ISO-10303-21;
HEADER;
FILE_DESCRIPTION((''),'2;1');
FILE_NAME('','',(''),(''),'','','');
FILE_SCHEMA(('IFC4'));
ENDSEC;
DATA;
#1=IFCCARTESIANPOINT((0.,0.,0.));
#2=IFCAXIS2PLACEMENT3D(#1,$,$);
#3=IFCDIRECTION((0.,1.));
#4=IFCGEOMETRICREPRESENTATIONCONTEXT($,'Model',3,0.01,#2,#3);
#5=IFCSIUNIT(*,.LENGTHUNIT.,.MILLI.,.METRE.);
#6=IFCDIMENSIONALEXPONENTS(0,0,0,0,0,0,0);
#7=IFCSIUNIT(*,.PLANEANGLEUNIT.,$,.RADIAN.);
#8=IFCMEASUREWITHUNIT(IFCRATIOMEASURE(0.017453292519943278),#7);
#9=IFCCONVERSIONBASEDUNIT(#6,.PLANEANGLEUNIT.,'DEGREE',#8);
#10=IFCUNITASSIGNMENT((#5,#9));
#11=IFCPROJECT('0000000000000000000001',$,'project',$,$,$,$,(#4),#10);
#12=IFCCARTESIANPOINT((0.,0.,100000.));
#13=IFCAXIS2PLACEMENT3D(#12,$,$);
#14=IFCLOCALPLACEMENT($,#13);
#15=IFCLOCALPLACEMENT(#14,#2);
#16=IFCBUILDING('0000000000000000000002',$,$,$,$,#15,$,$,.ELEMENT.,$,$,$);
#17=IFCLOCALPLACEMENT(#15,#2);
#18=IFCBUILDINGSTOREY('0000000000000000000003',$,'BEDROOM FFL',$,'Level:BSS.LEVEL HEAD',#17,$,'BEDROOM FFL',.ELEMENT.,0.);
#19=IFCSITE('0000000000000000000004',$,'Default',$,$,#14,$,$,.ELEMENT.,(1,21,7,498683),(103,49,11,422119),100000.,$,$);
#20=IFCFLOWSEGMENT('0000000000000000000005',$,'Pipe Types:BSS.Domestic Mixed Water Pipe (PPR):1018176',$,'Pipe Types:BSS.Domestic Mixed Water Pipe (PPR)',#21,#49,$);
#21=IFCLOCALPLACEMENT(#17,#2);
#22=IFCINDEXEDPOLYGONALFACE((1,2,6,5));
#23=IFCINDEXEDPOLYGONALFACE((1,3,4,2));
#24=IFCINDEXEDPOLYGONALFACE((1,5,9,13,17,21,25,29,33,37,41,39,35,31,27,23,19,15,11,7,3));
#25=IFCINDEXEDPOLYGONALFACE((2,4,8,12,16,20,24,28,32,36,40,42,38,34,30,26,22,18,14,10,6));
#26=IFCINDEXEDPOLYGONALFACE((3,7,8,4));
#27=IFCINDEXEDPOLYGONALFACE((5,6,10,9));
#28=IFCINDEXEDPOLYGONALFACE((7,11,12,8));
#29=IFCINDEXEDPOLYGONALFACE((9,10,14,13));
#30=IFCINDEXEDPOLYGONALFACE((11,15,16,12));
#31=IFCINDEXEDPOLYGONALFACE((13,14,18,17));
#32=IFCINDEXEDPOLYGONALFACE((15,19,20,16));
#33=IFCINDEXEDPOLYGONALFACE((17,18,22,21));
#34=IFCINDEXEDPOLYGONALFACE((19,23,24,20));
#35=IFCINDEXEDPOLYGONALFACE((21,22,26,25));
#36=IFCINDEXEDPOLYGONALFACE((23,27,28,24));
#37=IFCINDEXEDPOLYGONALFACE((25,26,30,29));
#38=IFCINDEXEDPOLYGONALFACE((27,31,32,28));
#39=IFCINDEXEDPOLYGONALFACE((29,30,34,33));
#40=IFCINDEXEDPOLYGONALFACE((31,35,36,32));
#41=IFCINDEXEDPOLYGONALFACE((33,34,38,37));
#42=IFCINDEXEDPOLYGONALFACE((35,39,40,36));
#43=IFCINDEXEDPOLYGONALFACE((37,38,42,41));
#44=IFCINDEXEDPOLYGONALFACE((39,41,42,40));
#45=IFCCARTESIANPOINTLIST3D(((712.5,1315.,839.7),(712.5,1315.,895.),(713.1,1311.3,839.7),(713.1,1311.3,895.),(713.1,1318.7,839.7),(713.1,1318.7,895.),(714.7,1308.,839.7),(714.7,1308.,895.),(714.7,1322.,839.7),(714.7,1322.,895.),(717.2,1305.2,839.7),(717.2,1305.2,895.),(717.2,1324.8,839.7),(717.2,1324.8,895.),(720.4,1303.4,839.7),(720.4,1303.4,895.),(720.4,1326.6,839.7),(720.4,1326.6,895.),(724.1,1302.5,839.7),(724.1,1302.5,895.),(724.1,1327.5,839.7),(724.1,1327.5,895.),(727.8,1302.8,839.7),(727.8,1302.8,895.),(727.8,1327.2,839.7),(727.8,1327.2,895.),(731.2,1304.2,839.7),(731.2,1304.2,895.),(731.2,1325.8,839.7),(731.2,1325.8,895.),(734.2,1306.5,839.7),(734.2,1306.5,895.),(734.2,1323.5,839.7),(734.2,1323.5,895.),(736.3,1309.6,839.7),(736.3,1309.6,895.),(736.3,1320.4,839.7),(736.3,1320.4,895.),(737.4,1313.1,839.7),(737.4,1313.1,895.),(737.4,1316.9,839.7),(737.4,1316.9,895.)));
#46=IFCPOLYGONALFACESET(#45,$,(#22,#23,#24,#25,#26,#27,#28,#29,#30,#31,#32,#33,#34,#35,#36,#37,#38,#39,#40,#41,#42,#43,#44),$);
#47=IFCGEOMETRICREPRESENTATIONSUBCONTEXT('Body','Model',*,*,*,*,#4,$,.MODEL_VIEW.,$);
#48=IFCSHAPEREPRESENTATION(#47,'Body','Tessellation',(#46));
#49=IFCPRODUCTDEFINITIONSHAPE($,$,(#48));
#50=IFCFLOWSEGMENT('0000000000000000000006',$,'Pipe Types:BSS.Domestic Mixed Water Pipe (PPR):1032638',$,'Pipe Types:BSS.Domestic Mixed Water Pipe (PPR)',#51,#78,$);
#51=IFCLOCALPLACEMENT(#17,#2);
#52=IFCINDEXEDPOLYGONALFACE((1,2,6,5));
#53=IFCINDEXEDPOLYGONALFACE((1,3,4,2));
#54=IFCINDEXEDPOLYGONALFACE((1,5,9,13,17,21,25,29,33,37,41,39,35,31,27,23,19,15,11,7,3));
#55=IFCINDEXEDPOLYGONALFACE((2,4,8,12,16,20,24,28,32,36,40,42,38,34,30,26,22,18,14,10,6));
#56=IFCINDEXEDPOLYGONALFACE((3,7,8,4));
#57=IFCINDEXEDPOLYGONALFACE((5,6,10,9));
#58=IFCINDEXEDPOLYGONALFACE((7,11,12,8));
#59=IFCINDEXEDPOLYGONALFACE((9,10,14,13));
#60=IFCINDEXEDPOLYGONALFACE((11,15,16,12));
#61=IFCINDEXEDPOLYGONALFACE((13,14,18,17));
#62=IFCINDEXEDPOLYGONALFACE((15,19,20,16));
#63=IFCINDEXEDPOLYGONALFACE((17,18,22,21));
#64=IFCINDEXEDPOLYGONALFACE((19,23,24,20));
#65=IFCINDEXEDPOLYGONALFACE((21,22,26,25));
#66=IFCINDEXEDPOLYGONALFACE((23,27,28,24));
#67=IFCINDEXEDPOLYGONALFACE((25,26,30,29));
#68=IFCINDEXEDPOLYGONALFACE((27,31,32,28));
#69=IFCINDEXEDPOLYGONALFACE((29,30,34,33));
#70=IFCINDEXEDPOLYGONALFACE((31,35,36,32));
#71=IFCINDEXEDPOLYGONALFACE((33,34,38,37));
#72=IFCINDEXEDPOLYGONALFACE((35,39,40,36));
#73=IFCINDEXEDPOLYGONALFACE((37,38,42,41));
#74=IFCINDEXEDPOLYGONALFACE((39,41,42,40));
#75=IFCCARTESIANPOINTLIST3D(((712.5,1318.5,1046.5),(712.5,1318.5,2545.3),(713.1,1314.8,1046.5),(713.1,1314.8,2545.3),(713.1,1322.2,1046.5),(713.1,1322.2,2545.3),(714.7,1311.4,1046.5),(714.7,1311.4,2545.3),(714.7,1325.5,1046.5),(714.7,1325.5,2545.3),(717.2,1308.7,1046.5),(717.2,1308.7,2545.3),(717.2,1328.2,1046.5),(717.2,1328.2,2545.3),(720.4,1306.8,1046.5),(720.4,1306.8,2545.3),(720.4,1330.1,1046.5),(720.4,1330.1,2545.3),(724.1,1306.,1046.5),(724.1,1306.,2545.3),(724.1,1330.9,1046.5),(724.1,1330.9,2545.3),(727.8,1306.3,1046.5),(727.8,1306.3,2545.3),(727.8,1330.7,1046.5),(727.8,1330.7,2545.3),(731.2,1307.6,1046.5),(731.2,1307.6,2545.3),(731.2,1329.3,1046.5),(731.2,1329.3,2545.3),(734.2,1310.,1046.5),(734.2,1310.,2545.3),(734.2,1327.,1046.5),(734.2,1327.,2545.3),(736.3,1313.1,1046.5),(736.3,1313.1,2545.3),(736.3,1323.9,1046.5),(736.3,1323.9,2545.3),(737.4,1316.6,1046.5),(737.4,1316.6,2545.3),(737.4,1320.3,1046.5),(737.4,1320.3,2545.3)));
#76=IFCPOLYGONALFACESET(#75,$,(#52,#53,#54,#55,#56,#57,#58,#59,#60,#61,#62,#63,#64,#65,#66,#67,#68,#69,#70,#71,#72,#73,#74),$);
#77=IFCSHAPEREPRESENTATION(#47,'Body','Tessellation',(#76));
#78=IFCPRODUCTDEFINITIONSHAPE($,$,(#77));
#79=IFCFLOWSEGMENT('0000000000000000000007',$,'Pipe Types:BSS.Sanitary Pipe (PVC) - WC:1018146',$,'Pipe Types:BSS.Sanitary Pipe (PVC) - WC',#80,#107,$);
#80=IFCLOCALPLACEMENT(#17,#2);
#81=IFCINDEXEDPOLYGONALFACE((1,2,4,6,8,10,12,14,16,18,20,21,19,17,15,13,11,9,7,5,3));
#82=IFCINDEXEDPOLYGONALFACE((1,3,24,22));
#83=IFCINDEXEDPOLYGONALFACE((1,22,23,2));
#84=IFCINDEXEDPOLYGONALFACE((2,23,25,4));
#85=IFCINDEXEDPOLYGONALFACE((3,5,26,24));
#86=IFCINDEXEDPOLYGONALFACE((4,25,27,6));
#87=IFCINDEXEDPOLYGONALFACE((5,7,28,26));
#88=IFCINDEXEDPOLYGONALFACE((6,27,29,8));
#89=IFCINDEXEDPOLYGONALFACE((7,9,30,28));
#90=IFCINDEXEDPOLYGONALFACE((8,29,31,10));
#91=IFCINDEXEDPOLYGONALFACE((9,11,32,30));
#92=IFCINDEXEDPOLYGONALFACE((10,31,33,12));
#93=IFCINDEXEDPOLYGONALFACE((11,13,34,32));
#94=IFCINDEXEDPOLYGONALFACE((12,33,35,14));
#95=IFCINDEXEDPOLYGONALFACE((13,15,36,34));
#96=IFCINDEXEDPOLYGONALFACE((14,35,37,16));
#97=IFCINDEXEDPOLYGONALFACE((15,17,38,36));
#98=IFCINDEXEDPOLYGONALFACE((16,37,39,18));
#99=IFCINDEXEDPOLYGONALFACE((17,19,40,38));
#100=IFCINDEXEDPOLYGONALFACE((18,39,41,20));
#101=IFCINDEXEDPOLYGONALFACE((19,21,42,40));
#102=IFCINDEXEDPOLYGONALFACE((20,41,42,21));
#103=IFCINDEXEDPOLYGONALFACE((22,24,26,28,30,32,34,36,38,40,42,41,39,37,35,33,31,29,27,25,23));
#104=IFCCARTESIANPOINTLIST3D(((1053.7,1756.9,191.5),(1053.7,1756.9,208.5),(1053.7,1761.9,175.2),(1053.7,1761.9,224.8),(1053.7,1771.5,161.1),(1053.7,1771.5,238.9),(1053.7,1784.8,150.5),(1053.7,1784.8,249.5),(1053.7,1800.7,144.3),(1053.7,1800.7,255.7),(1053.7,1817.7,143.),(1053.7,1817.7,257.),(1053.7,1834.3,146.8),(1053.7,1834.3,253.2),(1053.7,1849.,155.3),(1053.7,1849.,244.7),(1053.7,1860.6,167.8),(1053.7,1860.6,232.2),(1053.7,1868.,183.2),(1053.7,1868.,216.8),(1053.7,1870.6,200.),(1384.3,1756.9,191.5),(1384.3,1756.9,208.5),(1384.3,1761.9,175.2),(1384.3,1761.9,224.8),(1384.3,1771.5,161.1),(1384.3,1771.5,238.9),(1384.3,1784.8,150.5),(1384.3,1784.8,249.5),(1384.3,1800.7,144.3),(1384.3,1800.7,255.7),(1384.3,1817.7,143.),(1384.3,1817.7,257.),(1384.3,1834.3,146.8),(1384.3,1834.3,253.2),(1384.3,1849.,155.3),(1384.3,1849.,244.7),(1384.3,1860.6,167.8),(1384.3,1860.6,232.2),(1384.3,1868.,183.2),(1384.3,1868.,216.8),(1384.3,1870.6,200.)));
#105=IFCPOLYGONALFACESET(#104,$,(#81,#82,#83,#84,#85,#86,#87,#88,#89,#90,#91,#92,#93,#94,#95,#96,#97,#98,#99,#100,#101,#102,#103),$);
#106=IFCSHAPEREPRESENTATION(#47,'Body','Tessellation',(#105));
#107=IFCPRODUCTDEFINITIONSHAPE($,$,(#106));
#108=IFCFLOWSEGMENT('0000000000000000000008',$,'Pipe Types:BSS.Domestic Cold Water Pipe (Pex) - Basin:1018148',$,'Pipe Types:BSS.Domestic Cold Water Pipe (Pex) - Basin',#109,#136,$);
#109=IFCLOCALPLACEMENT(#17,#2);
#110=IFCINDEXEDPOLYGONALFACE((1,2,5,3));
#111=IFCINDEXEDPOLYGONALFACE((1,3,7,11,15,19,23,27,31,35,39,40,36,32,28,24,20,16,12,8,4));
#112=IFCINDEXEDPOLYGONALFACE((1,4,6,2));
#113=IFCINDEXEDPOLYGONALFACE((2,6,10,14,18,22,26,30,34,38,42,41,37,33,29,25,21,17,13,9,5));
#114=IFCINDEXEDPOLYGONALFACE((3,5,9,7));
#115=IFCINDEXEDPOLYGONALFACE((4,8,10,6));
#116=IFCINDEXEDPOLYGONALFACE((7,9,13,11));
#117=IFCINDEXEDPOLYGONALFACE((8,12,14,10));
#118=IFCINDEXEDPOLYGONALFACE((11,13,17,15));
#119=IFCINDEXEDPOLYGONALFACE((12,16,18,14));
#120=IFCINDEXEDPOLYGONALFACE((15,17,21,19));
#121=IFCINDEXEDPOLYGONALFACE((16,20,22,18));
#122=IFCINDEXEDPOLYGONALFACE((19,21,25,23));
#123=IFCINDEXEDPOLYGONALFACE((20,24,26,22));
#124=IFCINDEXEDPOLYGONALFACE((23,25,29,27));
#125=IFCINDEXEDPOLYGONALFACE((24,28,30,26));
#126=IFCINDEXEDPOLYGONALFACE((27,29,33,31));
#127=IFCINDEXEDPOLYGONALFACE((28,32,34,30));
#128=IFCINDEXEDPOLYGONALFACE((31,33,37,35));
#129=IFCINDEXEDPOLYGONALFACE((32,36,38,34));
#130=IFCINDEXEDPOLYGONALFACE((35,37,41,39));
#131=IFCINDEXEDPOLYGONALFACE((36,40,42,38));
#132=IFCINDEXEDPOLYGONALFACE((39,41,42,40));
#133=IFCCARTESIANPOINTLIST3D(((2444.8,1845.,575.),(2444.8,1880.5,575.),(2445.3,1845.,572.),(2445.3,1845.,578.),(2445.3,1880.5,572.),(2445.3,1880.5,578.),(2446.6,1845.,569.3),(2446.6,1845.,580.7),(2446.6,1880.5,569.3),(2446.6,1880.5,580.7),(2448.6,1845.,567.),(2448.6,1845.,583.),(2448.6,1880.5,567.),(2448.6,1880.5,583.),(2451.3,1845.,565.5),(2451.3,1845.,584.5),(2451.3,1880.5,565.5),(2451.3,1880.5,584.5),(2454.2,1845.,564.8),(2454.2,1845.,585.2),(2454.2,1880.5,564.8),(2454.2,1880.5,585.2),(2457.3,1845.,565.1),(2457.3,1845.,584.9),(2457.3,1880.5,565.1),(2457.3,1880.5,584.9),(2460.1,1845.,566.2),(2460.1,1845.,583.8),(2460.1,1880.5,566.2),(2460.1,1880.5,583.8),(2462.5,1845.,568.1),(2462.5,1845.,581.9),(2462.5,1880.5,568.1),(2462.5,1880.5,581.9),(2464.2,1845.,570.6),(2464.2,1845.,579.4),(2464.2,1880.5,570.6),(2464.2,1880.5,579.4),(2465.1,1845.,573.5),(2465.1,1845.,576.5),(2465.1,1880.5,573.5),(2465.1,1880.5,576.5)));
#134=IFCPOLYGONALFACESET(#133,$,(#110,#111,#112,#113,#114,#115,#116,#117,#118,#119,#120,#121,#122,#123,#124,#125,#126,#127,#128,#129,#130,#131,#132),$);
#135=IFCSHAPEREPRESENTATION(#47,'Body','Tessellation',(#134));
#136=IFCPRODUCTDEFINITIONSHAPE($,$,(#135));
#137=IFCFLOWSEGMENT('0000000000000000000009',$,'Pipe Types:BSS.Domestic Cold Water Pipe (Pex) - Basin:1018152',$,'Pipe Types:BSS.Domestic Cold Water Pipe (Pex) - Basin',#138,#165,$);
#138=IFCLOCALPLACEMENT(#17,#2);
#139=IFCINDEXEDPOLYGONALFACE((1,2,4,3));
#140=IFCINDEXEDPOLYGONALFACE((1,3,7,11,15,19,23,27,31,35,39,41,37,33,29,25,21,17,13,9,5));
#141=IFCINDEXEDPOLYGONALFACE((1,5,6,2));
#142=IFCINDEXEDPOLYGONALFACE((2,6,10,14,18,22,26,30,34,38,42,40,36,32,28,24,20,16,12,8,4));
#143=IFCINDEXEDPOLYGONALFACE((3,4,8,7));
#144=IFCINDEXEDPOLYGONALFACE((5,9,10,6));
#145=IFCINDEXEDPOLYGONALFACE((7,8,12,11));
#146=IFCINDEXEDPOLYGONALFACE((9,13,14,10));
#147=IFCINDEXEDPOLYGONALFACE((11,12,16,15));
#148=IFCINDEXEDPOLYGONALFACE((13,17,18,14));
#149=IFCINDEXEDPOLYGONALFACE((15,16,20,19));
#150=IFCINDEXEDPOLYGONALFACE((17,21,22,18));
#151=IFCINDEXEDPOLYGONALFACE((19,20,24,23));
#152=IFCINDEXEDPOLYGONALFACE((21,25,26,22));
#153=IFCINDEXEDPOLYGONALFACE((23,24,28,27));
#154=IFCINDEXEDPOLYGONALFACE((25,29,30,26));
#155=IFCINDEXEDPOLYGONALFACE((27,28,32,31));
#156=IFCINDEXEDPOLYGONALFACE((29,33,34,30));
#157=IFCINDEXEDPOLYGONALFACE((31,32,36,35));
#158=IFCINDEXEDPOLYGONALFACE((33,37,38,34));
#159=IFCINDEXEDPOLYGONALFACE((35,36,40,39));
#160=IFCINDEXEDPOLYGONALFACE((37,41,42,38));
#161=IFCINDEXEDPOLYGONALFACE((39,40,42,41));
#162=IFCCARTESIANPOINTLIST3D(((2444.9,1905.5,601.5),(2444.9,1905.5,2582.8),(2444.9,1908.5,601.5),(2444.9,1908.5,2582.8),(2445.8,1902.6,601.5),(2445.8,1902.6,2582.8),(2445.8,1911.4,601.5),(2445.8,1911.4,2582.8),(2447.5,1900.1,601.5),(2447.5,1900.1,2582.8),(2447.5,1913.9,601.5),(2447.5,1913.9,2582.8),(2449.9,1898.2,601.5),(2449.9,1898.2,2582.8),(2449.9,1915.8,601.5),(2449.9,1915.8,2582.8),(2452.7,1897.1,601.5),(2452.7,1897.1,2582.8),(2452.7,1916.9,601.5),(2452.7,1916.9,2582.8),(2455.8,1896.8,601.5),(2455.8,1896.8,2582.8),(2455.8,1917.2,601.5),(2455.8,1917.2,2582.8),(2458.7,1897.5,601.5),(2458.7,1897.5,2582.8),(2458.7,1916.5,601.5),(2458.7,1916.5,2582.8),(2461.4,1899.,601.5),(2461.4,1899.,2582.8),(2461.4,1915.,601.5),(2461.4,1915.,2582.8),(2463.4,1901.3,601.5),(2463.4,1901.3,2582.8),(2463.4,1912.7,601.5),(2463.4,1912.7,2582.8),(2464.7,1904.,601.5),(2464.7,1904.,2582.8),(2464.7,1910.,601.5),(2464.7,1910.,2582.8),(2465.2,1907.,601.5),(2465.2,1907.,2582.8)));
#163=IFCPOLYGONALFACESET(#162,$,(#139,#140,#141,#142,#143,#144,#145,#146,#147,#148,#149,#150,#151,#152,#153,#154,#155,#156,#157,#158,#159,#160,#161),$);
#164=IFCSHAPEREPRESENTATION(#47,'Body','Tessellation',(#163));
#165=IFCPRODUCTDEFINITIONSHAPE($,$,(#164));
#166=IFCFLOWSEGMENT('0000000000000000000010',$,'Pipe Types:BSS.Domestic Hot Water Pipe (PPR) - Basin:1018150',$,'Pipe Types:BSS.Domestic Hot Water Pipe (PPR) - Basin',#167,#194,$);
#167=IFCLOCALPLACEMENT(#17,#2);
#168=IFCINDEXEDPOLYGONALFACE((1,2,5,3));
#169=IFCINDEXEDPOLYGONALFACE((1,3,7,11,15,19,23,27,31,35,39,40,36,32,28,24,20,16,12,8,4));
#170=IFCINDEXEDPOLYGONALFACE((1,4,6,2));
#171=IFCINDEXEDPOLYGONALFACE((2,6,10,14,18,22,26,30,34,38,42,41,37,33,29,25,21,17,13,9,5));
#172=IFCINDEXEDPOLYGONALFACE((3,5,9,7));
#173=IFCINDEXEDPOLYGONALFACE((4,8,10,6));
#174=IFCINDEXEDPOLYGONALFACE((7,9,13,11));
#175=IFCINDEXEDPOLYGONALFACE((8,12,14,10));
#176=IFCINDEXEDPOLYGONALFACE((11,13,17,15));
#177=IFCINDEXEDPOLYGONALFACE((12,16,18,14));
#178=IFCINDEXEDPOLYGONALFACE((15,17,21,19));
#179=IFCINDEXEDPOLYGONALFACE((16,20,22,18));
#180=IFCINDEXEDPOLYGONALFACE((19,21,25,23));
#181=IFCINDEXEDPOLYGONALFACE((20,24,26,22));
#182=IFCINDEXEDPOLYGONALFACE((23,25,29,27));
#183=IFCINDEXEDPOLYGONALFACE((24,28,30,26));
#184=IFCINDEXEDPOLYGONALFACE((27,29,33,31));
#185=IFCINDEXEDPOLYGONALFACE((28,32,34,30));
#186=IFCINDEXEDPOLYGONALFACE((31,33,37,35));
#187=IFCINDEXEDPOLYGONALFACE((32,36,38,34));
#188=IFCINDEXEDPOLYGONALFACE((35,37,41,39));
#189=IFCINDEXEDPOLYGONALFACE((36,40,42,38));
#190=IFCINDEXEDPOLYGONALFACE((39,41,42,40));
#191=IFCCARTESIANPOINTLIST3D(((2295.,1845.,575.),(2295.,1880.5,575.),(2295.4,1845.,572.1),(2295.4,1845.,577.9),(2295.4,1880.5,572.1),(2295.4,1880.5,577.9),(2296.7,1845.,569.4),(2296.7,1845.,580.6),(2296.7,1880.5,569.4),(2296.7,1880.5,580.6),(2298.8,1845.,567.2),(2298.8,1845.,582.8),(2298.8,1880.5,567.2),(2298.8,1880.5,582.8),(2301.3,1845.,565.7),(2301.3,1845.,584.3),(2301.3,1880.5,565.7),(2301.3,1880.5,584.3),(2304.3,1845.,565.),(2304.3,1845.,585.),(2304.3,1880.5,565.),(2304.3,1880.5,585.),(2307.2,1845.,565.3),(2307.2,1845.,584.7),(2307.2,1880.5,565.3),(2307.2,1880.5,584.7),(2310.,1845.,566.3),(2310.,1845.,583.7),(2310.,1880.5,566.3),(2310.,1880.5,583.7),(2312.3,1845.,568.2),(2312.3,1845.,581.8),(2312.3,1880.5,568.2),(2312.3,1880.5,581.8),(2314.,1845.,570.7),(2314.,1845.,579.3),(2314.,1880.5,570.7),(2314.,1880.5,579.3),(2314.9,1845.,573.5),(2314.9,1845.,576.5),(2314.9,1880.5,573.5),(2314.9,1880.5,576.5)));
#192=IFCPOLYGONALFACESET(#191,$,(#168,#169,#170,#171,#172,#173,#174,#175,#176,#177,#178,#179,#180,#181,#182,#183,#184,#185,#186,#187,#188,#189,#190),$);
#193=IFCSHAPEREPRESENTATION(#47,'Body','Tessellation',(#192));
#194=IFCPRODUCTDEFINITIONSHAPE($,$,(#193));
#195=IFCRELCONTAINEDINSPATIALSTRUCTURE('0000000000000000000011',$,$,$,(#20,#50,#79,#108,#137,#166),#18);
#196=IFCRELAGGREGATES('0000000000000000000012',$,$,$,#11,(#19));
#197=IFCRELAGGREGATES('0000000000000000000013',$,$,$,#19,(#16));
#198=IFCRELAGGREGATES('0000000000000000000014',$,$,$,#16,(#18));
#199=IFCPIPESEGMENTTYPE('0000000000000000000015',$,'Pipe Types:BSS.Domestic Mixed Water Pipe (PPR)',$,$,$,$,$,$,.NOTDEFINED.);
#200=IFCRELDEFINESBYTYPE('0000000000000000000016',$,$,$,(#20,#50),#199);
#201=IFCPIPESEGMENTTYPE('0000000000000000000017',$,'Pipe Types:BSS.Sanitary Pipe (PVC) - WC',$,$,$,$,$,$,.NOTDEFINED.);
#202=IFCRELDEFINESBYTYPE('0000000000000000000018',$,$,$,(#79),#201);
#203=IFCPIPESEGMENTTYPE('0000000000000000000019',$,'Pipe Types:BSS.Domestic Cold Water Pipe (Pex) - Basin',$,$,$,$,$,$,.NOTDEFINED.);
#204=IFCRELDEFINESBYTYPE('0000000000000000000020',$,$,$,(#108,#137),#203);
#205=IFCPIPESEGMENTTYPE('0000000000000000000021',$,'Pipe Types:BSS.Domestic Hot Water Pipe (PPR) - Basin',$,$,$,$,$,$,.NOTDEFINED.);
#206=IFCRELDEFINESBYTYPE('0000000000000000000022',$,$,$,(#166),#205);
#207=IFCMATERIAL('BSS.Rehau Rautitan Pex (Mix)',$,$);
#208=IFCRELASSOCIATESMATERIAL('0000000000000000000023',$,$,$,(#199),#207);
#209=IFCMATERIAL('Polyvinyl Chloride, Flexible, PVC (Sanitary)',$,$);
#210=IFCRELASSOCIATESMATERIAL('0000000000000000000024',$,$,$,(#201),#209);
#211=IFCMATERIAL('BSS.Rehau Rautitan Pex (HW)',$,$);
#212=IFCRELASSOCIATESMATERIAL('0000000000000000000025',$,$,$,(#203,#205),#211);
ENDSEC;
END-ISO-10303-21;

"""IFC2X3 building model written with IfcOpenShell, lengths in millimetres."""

from ifc_helpers import new_model, entity, si_unit, converted_unit, direction, frame, frame_2d, origin, origin_2d_with_axis, place, context, subcontext, project, spatial, circle, extrude, material, type_object, element, save


model = new_model("IFC2X3")

# Units and contexts
model_context = context("Model", 3, precision=0.01, world=origin(), true_north=direction((0.0, 1.0)))
body_context = subcontext(model_context, "Body", "Model", "MODEL_VIEW")
ifc_project = project(units=[si_unit("LENGTHUNIT", "METRE", prefix="MILLI"), converted_unit("PLANEANGLEUNIT", "DEGREE", entity("IfcRatioMeasure", 0.017453292519943278), si_unit("PLANEANGLEUNIT", "RADIAN"), dimensions=[0, 0, 0, 0, 0, 0, 0])], contexts=[model_context])

# Site, building, storey
site_placement = place(None, frame((0.0, 0.0, 100000.0)))
site = spatial("IfcSite", under=ifc_project, at=site_placement, Name="Default", CompositionType="ELEMENT", RefLatitude=(1, 21, 7, 498683), RefLongitude=(103, 49, 11, 422119), RefElevation=100000.0)
building_placement = place(site_placement, origin())
building = spatial("IfcBuilding", under=site, at=building_placement, CompositionType="ELEMENT")
storey_placement = place(building_placement, origin())
storey = spatial("IfcBuildingStorey", under=building, at=storey_placement, Name="BEDROOM FFL", ObjectType="Level:BSS.LEVEL HEAD", LongName="BEDROOM FFL", CompositionType="ELEMENT", Elevation=0.0)

# Flow segments
ifc_material_1 = material(Name="Polyvinyl Chloride, Flexible, PVC (Sanitary)")
ifc_material_2 = material(Name="BSS.Rehau Rautitan Pex (Mix)")
pipe_segment_type_1 = type_object("IfcPipeSegmentType", Name="Pipe Types:BSS.Domestic Mixed Water Pipe (PPR)", PredefinedType="NOTDEFINED", material=ifc_material_2)
flow_segment_1_placement = place(storey_placement, origin())
element("IfcFlowSegment", 1, at=flow_segment_1_placement, inside=storey, type_object=pipe_segment_type_1, Name="Pipe Types:BSS.Domestic Mixed Water Pipe (PPR):1018176", ObjectType="Pipe Types:BSS.Domestic Mixed Water Pipe (PPR)", context=body_context, shape_type="SweptSolid", body=[
    extrude(circle(Radius=12.5, at=origin_2d_with_axis()), frame((725.0, 1315.0, 839.7), z_axis=(0.0, 0.0, 1.0), x_axis=(-1.0, 0.0, 0.0)), (0.0, 0.0, 1.0), 55.3),
])
flow_segment_2_placement = place(storey_placement, origin())
element("IfcFlowSegment", 2, at=flow_segment_2_placement, inside=storey, type_object=pipe_segment_type_1, Name="Pipe Types:BSS.Domestic Mixed Water Pipe (PPR):1032638", ObjectType="Pipe Types:BSS.Domestic Mixed Water Pipe (PPR)", context=body_context, shape_type="SweptSolid", body=[
    extrude(circle(Radius=12.5, at=frame_2d((0.0, 0.0), x_axis=(1.0, 0.0))), frame((725.0, 1318.5, 1046.5), z_axis=(0.0, 0.0, 1.0), x_axis=(-1.0, 0.0, 0.0)), (0.0, 0.0, 1.0), 1498.8),
])
pipe_segment_type_2 = type_object("IfcPipeSegmentType", Name="Pipe Types:BSS.Sanitary Pipe (PVC) - WC", PredefinedType="NOTDEFINED", material=ifc_material_1)
flow_segment_3_placement = place(storey_placement, origin())
element("IfcFlowSegment", 3, at=flow_segment_3_placement, inside=storey, type_object=pipe_segment_type_2, Name="Pipe Types:BSS.Sanitary Pipe (PVC) - WC:1018146", ObjectType="Pipe Types:BSS.Sanitary Pipe (PVC) - WC", context=body_context, shape_type="SweptSolid", body=[
    extrude(circle(Radius=57.2, at=frame_2d((0.0, 0.0), x_axis=(1.0, 0.0))), frame((1053.7, 1813.4, 200.0), z_axis=(1.0, 0.0, 0.0), x_axis=(0.0, 1.0, 0.0)), (0.0, 0.0, 1.0), 330.6),
])
ifc_material_3 = material(Name="BSS.Rehau Rautitan Pex (HW)")
pipe_segment_type_3 = type_object("IfcPipeSegmentType", Name="Pipe Types:BSS.Domestic Cold Water Pipe (Pex) - Basin", PredefinedType="NOTDEFINED", material=ifc_material_3)
flow_segment_4_placement = place(storey_placement, origin())
element("IfcFlowSegment", 4, at=flow_segment_4_placement, inside=storey, type_object=pipe_segment_type_3, Name="Pipe Types:BSS.Domestic Cold Water Pipe (Pex) - Basin:1018148", ObjectType="Pipe Types:BSS.Domestic Cold Water Pipe (Pex) - Basin", context=body_context, shape_type="SweptSolid", body=[
    extrude(circle(Radius=10.2, at=frame_2d((0.0, 0.0), x_axis=(1.0, 0.0))), frame((2455.0, 1845.0, 575.0), z_axis=(0.0, 1.0, 0.0), x_axis=(-1.0, 0.0, 0.0)), (0.0, 0.0, 1.0), 35.5),
])
flow_segment_5_placement = place(storey_placement, origin())
element("IfcFlowSegment", 5, at=flow_segment_5_placement, inside=storey, type_object=pipe_segment_type_3, Name="Pipe Types:BSS.Domestic Cold Water Pipe (Pex) - Basin:1018152", ObjectType="Pipe Types:BSS.Domestic Cold Water Pipe (Pex) - Basin", context=body_context, shape_type="SweptSolid", body=[
    extrude(circle(Radius=10.2, at=frame_2d((0.0, 0.0), x_axis=(1.0, 0.0))), frame((2455.0, 1907.0, 601.5)), (0.0, 0.0, 1.0), 1981.3),
])
pipe_segment_type_4 = type_object("IfcPipeSegmentType", Name="Pipe Types:BSS.Domestic Hot Water Pipe (PPR) - Basin", PredefinedType="NOTDEFINED", material=ifc_material_3)
flow_segment_6_placement = place(storey_placement, origin())
element("IfcFlowSegment", 6, at=flow_segment_6_placement, inside=storey, type_object=pipe_segment_type_4, Name="Pipe Types:BSS.Domestic Hot Water Pipe (PPR) - Basin:1018150", ObjectType="Pipe Types:BSS.Domestic Hot Water Pipe (PPR) - Basin", context=body_context, shape_type="SweptSolid", body=[
    extrude(circle(Radius=10.0, at=origin_2d_with_axis()), frame((2305.0, 1845.0, 575.0), z_axis=(0.000001, 1.0, 0.0), x_axis=(-1.0, 0.000001, 0.0)), (0.0, 0.0, 1.0), 35.5),
])

save(model, "model.ifc")
